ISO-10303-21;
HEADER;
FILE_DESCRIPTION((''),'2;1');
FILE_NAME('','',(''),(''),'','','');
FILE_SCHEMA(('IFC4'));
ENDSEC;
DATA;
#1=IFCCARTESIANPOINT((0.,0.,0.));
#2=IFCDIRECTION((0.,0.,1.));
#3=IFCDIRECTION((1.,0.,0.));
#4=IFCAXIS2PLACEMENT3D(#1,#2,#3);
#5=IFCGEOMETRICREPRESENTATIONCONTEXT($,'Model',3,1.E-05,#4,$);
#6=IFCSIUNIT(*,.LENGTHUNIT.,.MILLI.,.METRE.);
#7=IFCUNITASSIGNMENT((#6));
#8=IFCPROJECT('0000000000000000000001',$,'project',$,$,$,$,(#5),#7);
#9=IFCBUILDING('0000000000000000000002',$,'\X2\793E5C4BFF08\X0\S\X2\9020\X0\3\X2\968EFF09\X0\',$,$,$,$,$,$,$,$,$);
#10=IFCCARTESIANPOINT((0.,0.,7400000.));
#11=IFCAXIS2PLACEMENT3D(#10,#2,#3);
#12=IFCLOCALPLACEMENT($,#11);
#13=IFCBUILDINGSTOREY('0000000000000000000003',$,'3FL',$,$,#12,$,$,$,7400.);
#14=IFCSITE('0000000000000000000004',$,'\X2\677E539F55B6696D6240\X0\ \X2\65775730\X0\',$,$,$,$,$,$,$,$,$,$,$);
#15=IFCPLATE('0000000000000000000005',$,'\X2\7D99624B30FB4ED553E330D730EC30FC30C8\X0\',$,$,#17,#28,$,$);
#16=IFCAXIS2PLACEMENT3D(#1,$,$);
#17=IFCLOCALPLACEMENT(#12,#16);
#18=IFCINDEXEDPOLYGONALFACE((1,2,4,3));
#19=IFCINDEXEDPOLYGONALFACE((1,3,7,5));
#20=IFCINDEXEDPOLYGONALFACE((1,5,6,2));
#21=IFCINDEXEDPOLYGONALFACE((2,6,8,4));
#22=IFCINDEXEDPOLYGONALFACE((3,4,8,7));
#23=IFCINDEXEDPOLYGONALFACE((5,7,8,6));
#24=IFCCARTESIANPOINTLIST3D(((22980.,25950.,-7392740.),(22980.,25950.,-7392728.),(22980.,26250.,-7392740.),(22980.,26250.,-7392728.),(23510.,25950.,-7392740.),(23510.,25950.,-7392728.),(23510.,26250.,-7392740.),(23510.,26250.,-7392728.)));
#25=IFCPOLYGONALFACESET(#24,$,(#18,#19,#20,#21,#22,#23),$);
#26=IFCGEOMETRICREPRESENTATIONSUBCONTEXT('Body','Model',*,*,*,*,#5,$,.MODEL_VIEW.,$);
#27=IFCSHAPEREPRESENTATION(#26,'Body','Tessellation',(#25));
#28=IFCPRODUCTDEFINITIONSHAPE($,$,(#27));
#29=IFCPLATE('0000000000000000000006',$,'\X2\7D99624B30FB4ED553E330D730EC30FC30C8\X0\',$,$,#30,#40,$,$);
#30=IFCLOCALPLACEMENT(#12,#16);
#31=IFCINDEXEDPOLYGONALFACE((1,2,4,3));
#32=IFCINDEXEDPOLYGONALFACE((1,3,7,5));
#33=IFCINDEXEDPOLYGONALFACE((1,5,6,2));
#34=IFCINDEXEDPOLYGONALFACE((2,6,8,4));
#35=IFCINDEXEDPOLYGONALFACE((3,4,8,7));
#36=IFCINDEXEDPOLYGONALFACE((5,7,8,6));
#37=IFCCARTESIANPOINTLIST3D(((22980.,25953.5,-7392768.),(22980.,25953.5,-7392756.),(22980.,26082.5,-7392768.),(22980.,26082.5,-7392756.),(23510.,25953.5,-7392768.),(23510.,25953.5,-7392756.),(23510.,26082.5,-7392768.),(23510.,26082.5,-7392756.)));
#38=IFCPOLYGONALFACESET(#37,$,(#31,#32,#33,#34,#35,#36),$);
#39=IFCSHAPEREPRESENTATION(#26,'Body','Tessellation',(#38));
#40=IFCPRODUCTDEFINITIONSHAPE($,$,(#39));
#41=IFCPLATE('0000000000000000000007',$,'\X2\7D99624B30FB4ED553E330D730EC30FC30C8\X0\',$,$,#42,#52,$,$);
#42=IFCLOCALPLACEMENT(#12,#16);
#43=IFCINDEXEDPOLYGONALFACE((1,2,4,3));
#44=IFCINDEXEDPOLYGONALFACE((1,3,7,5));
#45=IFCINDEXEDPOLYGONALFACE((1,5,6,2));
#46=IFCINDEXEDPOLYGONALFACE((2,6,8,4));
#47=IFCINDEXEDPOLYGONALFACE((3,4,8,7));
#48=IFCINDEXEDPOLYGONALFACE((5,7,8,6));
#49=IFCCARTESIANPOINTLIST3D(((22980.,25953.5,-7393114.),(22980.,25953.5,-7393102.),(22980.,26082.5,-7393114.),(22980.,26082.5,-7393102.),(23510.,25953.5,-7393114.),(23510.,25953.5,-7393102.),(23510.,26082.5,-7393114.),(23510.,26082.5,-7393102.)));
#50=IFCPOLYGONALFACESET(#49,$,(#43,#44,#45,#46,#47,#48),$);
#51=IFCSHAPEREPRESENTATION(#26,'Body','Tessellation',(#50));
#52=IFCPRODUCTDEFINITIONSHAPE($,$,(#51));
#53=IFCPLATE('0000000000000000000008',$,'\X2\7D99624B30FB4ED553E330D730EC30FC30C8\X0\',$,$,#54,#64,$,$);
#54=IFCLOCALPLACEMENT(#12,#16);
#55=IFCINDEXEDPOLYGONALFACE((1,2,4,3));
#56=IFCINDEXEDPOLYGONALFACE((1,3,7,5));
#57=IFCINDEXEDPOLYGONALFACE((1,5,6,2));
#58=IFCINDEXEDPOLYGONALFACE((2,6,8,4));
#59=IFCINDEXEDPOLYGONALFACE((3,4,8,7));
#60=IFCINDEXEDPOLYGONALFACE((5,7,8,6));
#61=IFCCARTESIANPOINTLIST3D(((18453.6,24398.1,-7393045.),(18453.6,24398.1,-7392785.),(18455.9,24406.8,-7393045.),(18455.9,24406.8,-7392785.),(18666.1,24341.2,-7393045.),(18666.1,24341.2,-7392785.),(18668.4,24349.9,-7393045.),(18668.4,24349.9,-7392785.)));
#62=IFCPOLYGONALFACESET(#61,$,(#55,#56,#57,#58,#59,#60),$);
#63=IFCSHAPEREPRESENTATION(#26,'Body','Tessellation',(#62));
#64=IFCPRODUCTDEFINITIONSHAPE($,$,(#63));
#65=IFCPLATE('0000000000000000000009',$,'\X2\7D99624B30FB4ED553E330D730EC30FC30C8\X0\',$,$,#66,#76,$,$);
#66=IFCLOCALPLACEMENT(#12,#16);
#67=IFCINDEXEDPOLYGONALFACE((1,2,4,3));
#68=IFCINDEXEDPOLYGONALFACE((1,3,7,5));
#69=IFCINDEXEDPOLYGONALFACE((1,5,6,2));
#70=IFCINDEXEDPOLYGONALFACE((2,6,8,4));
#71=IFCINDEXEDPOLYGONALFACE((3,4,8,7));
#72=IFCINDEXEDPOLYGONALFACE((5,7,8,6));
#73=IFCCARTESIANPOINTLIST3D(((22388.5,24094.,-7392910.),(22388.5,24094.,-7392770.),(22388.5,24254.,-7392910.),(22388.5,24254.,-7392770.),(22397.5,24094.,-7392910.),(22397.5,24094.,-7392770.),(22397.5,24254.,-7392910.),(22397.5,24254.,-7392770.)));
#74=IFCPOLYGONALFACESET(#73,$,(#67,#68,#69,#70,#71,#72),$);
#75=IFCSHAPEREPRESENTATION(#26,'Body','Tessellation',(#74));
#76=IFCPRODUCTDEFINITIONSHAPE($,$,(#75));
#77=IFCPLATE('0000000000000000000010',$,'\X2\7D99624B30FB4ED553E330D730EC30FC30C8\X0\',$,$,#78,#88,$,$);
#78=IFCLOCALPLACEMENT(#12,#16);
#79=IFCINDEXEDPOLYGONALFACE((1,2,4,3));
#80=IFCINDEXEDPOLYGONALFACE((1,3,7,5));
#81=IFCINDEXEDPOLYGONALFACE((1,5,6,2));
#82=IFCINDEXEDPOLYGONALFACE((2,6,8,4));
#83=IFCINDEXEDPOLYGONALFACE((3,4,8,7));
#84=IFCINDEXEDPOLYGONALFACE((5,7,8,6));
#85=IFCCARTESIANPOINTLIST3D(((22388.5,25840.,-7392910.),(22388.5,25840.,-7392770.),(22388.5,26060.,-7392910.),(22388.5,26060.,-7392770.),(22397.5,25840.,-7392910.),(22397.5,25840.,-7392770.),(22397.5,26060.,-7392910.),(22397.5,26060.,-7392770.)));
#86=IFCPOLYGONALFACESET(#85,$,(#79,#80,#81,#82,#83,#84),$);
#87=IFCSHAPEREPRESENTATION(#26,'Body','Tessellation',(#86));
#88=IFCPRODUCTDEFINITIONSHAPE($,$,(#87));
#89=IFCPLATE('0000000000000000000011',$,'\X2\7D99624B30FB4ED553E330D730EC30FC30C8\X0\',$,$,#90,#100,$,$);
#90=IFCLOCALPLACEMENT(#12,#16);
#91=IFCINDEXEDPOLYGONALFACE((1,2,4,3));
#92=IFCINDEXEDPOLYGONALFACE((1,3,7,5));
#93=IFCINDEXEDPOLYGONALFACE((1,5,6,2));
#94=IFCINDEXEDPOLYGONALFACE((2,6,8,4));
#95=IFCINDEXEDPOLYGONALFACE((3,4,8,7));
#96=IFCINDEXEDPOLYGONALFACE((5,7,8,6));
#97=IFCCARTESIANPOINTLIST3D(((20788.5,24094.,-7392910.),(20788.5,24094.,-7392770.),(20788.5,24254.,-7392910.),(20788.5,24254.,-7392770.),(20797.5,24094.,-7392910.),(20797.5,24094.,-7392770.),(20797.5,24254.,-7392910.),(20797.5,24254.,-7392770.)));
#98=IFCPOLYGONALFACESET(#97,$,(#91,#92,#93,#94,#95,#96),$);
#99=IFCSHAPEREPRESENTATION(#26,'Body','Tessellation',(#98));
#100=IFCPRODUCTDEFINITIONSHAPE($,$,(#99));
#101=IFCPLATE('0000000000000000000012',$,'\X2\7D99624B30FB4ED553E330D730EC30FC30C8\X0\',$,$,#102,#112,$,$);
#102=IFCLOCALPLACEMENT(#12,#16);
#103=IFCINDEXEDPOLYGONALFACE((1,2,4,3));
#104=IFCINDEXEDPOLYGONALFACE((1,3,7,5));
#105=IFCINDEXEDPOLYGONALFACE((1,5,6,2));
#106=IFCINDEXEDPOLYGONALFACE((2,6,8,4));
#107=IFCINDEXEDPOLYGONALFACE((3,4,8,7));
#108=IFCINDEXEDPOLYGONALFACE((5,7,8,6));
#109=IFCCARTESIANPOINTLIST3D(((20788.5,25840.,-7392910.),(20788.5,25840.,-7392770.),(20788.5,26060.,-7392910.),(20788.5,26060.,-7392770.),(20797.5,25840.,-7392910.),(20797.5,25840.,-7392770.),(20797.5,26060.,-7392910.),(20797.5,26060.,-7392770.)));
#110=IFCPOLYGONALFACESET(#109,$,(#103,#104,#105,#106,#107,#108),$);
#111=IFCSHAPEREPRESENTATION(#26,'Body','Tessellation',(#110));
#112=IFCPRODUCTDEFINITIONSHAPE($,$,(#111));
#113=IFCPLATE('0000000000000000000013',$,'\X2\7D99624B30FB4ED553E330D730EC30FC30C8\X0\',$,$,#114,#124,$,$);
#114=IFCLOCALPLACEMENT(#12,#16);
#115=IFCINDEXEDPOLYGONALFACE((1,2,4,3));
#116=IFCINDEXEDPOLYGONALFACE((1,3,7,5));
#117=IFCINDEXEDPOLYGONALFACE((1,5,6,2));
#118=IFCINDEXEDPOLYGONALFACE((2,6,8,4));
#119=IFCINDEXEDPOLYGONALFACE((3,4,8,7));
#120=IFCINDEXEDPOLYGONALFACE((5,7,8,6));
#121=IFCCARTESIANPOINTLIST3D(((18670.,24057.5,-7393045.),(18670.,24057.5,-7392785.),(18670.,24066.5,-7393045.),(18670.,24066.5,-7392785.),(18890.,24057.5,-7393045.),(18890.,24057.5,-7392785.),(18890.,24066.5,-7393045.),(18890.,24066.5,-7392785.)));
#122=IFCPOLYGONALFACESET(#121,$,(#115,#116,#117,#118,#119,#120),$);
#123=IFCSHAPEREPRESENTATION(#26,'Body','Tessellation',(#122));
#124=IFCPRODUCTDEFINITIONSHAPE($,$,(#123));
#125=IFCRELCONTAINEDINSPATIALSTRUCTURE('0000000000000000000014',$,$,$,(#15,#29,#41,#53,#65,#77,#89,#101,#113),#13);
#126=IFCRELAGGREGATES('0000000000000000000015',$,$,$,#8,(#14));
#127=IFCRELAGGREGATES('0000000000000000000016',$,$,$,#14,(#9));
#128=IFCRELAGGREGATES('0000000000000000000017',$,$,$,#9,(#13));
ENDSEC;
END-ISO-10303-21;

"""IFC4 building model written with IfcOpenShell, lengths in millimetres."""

from ifc_helpers import new_model, si_unit, frame, origin, origin_with_axes, place, context, subcontext, project, spatial, rectangle, extrude, element, save


model = new_model("IFC4")

# Units and contexts
model_context = context("Model", 3, precision=1e-05, world=origin_with_axes())
body_context = subcontext(model_context, "Body", "Model", "MODEL_VIEW")
ifc_project = project(units=[si_unit("LENGTHUNIT", "METRE", prefix="MILLI")], contexts=[model_context])

# Site, building, storey
site = spatial("IfcSite", under=ifc_project, Name="松原営業所 敷地")
building = spatial("IfcBuilding", under=site, Name="社屋（S造3階）")
storey_placement = place(None, frame((0.0, 0.0, 7400000.0), z_axis=(0.0, 0.0, 1.0), x_axis=(1.0, 0.0, 0.0)))
storey = spatial("IfcBuildingStorey", under=building, at=storey_placement, Name="3FL", Elevation=7400.0)

# Plates
plate_1_placement = place(storey_placement, frame((22980.0, 26100.0, -7392734.0), z_axis=(1.0, 0.0, 0.0), x_axis=(0.0, 1.0, 0.0)))
element("IfcPlate", 1, at=plate_1_placement, inside=storey, Name="継手・仕口プレート", context=body_context, shape_type="SweptSolid", body=[
    extrude(rectangle(XDim=300.0, YDim=12.0), origin(), (0.0, 0.0, 1.0), 530.0),
])
for number, where, z_axis, x_axis, name in (
    (2, (22980.0, 26018.0, -7392762.0), (1.0, 0.0, 0.0), (0.0, 1.0, 0.0), "継手・仕口プレート"),
    (3, (22980.0, 26018.0, -7393108.0), (1.0, 0.0, 0.0), (0.0, 1.0, 0.0), "継手・仕口プレート"),
):
    element("IfcPlate", number, at=place(storey_placement, frame(where, z_axis=z_axis, x_axis=x_axis)), inside=storey, Name=name, context=body_context, shape_type="SweptSolid", body=[
        extrude(rectangle(XDim=129.0, YDim=12.0), origin(), (0.0, 0.0, 1.0), 530.0),
    ])
plate_2_placement = place(storey_placement, frame((18454.7, 24402.5, -7392915.0), z_axis=(0.965926, -0.258819, 0.0), x_axis=(0.258819, 0.965926, 0.0)))
element("IfcPlate", 4, at=plate_2_placement, inside=storey, Name="継手・仕口プレート", context=body_context, shape_type="SweptSolid", body=[
    extrude(rectangle(XDim=9.0, YDim=260.0), origin(), (0.0, 0.0, 1.0), 220.0),
])
plate_3_placement = place(storey_placement, frame((22393.0, 24094.0, -7392840.0), z_axis=(0.0, 1.0, 0.0), x_axis=(-1.0, 0.0, 0.0)))
element("IfcPlate", 5, at=plate_3_placement, inside=storey, Name="継手・仕口プレート", context=body_context, shape_type="SweptSolid", body=[
    extrude(rectangle(XDim=9.0, YDim=140.0), origin(), (0.0, 0.0, 1.0), 160.0),
])
plate_4_placement = place(storey_placement, frame((22393.0, 25840.0, -7392840.0), z_axis=(0.0, 1.0, 0.0), x_axis=(-1.0, 0.0, 0.0)))
element("IfcPlate", 6, at=plate_4_placement, inside=storey, Name="継手・仕口プレート", context=body_context, shape_type="SweptSolid", body=[
    extrude(rectangle(XDim=9.0, YDim=140.0), origin(), (0.0, 0.0, 1.0), 220.0),
])
plate_5_placement = place(storey_placement, frame((20793.0, 24094.0, -7392840.0), z_axis=(0.0, 1.0, 0.0), x_axis=(-1.0, 0.0, 0.0)))
element("IfcPlate", 7, at=plate_5_placement, inside=storey, Name="継手・仕口プレート", context=body_context, shape_type="SweptSolid", body=[
    extrude(rectangle(XDim=9.0, YDim=140.0), origin(), (0.0, 0.0, 1.0), 160.0),
])
plate_6_placement = place(storey_placement, frame((20793.0, 25840.0, -7392840.0), z_axis=(0.0, 1.0, 0.0), x_axis=(-1.0, 0.0, 0.0)))
element("IfcPlate", 8, at=plate_6_placement, inside=storey, Name="継手・仕口プレート", context=body_context, shape_type="SweptSolid", body=[
    extrude(rectangle(XDim=9.0, YDim=140.0), origin(), (0.0, 0.0, 1.0), 220.0),
])
plate_7_placement = place(storey_placement, frame((18670.0, 24062.0, -7392915.0), z_axis=(1.0, 0.0, 0.0), x_axis=(0.0, 1.0, 0.0)))
element("IfcPlate", 9, at=plate_7_placement, inside=storey, Name="継手・仕口プレート", context=body_context, shape_type="SweptSolid", body=[
    extrude(rectangle(XDim=9.0, YDim=260.0), origin(), (0.0, 0.0, 1.0), 220.0),
])

save(model, "model.ifc")
